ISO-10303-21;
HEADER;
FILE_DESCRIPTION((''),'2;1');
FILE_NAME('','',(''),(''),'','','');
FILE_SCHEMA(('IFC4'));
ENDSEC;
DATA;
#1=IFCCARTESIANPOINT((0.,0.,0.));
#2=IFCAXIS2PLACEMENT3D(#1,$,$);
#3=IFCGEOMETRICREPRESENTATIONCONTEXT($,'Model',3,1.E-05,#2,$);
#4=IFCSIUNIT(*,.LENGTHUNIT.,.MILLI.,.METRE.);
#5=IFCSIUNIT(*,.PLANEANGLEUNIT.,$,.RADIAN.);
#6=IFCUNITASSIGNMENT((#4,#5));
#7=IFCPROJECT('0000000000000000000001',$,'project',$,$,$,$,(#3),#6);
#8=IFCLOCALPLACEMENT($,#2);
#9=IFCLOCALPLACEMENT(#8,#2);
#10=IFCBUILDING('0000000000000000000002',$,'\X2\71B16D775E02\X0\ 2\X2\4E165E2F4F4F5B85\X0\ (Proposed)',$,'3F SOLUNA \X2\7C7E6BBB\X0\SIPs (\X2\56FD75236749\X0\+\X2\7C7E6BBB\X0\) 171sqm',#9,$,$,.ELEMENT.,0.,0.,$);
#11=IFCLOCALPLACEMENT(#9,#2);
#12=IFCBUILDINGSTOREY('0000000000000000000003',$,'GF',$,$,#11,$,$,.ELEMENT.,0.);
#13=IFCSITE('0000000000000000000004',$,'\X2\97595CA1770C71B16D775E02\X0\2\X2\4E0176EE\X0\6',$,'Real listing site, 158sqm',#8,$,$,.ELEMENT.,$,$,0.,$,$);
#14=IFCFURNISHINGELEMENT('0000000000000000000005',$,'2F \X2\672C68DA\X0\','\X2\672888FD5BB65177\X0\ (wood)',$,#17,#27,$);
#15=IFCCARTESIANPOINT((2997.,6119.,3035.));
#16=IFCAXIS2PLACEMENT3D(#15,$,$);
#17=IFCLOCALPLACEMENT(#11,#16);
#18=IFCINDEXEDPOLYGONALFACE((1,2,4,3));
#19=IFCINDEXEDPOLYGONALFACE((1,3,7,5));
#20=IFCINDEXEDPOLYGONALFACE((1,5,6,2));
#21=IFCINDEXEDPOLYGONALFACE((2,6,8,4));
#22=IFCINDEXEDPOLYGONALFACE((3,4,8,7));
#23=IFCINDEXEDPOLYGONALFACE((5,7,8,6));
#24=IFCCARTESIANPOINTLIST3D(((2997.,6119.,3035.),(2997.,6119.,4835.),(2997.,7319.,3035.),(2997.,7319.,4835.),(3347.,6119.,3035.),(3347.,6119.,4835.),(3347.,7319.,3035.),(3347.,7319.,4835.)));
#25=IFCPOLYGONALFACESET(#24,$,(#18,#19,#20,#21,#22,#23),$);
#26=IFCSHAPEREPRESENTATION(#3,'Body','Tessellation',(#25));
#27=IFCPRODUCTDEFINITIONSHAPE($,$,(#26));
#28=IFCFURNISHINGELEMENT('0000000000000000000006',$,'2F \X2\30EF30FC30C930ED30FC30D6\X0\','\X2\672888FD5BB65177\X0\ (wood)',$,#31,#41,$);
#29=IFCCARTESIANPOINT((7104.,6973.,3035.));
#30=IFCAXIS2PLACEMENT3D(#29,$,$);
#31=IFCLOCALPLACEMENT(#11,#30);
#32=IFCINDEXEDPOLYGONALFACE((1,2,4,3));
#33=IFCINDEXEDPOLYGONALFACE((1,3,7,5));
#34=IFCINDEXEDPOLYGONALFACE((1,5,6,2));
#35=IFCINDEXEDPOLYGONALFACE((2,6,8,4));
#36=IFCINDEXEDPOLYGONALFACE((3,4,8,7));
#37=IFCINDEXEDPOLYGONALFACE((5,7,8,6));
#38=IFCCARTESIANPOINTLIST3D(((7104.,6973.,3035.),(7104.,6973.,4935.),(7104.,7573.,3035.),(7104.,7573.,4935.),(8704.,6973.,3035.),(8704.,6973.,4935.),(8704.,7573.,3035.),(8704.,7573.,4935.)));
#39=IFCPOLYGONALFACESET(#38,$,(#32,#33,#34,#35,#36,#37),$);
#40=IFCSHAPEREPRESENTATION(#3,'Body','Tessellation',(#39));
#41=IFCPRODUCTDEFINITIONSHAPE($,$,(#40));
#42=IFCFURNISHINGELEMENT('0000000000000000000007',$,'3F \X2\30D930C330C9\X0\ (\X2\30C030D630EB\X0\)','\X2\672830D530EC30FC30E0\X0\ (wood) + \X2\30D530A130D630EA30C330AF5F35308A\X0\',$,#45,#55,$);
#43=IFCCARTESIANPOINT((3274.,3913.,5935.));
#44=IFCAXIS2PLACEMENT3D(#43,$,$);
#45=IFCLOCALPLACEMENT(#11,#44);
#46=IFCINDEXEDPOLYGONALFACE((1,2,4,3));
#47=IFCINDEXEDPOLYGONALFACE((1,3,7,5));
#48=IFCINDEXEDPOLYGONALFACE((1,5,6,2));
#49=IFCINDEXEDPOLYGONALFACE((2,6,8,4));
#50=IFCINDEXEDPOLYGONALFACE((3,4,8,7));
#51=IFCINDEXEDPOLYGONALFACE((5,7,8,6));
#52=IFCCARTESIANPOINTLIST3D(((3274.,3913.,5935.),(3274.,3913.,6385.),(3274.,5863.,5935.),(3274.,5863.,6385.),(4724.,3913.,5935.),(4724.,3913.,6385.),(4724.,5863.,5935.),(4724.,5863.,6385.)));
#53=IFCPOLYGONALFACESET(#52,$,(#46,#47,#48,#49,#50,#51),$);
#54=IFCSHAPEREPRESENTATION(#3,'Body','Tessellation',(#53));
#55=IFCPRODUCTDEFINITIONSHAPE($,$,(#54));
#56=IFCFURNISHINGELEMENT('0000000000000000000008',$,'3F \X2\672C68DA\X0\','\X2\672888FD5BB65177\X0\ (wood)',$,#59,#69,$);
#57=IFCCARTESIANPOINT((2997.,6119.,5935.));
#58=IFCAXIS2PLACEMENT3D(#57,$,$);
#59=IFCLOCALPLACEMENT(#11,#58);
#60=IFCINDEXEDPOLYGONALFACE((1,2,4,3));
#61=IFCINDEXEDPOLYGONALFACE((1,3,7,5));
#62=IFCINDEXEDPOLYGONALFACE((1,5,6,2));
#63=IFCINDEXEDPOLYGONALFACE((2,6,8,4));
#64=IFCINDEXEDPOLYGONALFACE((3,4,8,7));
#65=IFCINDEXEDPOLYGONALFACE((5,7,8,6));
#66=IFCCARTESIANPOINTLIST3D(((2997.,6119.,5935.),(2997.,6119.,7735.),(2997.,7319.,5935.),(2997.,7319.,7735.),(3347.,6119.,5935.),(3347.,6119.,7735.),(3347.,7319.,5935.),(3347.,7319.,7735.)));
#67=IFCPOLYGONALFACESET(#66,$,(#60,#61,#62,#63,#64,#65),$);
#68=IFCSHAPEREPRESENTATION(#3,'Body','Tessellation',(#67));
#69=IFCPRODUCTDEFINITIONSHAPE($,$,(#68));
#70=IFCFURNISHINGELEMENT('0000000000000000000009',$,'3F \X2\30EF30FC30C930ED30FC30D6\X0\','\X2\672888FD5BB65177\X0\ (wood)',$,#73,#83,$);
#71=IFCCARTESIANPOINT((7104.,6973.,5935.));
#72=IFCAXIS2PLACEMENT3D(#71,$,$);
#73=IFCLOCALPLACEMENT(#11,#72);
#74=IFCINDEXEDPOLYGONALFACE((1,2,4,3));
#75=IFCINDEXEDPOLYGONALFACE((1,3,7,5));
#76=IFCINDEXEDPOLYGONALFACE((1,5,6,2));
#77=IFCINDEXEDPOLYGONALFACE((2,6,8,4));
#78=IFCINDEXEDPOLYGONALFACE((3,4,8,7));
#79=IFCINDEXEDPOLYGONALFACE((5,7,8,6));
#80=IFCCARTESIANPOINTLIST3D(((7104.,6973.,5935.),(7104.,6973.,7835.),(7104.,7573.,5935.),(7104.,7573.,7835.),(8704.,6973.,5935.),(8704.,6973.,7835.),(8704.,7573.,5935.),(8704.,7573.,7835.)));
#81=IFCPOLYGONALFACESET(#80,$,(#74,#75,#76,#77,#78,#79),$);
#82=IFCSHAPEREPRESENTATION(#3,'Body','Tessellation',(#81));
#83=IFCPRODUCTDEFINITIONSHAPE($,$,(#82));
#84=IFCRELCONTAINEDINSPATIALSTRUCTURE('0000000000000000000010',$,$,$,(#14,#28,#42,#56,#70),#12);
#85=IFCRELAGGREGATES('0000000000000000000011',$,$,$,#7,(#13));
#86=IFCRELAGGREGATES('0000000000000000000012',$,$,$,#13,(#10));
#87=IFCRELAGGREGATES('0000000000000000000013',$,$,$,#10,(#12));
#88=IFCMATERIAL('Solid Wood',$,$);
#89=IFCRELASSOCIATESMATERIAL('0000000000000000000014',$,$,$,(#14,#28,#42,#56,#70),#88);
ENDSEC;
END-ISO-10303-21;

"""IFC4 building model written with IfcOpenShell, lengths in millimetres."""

from ifc_helpers import new_model, si_unit, frame, frame_2d, origin, place, context, project, spatial, rectangle, extrude, material, element, save


model = new_model("IFC4")

# Units and contexts
model_context = context("Model", 3, precision=1e-05, world=origin())
ifc_project = project(units=[si_unit("LENGTHUNIT", "METRE", prefix="MILLI"), si_unit("PLANEANGLEUNIT", "RADIAN")], contexts=[model_context])

# Site, building, storey
site_placement = place(None, origin())
site = spatial("IfcSite", under=ifc_project, at=site_placement, Name="静岡県熱海市2丁目6", ObjectType="Real listing site, 158sqm", CompositionType="ELEMENT", RefElevation=0.0)
building_placement = place(site_placement, origin())
building = spatial("IfcBuilding", under=site, at=building_placement, Name="熱海市 2世帯住宅 (Proposed)", ObjectType="3F SOLUNA 籾殻SIPs (国産杉+籾殻) 171sqm", CompositionType="ELEMENT", ElevationOfRefHeight=0.0, ElevationOfTerrain=0.0)
storey_placement = place(building_placement, origin())
storey = spatial("IfcBuildingStorey", under=building, at=storey_placement, Name="GF", CompositionType="ELEMENT", Elevation=0.0)

# Shared definitions
ifc_material_1 = material(Name="Solid Wood")

# Furnishing elements
furnishing_1_placement = place(storey_placement, frame((2997.0, 6119.0, 3035.0)))
element("IfcFurnishingElement", 1, at=furnishing_1_placement, inside=storey, material=ifc_material_1, Name="2F 本棚", Description="木製家具 (wood)", context=model_context, shape_type="SweptSolid", body=[
    extrude(rectangle(XDim=350.0, YDim=1200.0, at=frame_2d((175.0, 600.0))), frame((2997.0, 6119.0, 3035.0)), (0.0, 0.0, 1.0), 1800.0),
])
furnishing_2_placement = place(storey_placement, frame((7104.0, 6973.0, 3035.0)))
element("IfcFurnishingElement", 2, at=furnishing_2_placement, inside=storey, material=ifc_material_1, Name="2F ワードローブ", Description="木製家具 (wood)", context=model_context, shape_type="SweptSolid", body=[
    extrude(rectangle(XDim=1600.0, YDim=600.0, at=frame_2d((800.0, 300.0))), frame((7104.0, 6973.0, 3035.0)), (0.0, 0.0, 1.0), 1900.0),
])
furnishing_3_placement = place(storey_placement, frame((3274.0, 3913.0, 5935.0)))
element("IfcFurnishingElement", 3, at=furnishing_3_placement, inside=storey, material=ifc_material_1, Name="3F ベッド (ダブル)", Description="木フレーム (wood) + ファブリック張り", context=model_context, shape_type="SweptSolid", body=[
    extrude(rectangle(XDim=1450.0, YDim=1950.0, at=frame_2d((725.0, 975.0))), frame((3274.0, 3913.0, 5935.0)), (0.0, 0.0, 1.0), 450.0),
])
furnishing_4_placement = place(storey_placement, frame((2997.0, 6119.0, 5935.0)))
element("IfcFurnishingElement", 4, at=furnishing_4_placement, inside=storey, material=ifc_material_1, Name="3F 本棚", Description="木製家具 (wood)", context=model_context, shape_type="SweptSolid", body=[
    extrude(rectangle(XDim=350.0, YDim=1200.0, at=frame_2d((175.0, 600.0))), frame((2997.0, 6119.0, 5935.0)), (0.0, 0.0, 1.0), 1800.0),
])
furnishing_5_placement = place(storey_placement, frame((7104.0, 6973.0, 5935.0)))
element("IfcFurnishingElement", 5, at=furnishing_5_placement, inside=storey, material=ifc_material_1, Name="3F ワードローブ", Description="木製家具 (wood)", context=model_context, shape_type="SweptSolid", body=[
    extrude(rectangle(XDim=1600.0, YDim=600.0, at=frame_2d((800.0, 300.0))), frame((7104.0, 6973.0, 5935.0)), (0.0, 0.0, 1.0), 1900.0),
])

save(model, "model.ifc")
